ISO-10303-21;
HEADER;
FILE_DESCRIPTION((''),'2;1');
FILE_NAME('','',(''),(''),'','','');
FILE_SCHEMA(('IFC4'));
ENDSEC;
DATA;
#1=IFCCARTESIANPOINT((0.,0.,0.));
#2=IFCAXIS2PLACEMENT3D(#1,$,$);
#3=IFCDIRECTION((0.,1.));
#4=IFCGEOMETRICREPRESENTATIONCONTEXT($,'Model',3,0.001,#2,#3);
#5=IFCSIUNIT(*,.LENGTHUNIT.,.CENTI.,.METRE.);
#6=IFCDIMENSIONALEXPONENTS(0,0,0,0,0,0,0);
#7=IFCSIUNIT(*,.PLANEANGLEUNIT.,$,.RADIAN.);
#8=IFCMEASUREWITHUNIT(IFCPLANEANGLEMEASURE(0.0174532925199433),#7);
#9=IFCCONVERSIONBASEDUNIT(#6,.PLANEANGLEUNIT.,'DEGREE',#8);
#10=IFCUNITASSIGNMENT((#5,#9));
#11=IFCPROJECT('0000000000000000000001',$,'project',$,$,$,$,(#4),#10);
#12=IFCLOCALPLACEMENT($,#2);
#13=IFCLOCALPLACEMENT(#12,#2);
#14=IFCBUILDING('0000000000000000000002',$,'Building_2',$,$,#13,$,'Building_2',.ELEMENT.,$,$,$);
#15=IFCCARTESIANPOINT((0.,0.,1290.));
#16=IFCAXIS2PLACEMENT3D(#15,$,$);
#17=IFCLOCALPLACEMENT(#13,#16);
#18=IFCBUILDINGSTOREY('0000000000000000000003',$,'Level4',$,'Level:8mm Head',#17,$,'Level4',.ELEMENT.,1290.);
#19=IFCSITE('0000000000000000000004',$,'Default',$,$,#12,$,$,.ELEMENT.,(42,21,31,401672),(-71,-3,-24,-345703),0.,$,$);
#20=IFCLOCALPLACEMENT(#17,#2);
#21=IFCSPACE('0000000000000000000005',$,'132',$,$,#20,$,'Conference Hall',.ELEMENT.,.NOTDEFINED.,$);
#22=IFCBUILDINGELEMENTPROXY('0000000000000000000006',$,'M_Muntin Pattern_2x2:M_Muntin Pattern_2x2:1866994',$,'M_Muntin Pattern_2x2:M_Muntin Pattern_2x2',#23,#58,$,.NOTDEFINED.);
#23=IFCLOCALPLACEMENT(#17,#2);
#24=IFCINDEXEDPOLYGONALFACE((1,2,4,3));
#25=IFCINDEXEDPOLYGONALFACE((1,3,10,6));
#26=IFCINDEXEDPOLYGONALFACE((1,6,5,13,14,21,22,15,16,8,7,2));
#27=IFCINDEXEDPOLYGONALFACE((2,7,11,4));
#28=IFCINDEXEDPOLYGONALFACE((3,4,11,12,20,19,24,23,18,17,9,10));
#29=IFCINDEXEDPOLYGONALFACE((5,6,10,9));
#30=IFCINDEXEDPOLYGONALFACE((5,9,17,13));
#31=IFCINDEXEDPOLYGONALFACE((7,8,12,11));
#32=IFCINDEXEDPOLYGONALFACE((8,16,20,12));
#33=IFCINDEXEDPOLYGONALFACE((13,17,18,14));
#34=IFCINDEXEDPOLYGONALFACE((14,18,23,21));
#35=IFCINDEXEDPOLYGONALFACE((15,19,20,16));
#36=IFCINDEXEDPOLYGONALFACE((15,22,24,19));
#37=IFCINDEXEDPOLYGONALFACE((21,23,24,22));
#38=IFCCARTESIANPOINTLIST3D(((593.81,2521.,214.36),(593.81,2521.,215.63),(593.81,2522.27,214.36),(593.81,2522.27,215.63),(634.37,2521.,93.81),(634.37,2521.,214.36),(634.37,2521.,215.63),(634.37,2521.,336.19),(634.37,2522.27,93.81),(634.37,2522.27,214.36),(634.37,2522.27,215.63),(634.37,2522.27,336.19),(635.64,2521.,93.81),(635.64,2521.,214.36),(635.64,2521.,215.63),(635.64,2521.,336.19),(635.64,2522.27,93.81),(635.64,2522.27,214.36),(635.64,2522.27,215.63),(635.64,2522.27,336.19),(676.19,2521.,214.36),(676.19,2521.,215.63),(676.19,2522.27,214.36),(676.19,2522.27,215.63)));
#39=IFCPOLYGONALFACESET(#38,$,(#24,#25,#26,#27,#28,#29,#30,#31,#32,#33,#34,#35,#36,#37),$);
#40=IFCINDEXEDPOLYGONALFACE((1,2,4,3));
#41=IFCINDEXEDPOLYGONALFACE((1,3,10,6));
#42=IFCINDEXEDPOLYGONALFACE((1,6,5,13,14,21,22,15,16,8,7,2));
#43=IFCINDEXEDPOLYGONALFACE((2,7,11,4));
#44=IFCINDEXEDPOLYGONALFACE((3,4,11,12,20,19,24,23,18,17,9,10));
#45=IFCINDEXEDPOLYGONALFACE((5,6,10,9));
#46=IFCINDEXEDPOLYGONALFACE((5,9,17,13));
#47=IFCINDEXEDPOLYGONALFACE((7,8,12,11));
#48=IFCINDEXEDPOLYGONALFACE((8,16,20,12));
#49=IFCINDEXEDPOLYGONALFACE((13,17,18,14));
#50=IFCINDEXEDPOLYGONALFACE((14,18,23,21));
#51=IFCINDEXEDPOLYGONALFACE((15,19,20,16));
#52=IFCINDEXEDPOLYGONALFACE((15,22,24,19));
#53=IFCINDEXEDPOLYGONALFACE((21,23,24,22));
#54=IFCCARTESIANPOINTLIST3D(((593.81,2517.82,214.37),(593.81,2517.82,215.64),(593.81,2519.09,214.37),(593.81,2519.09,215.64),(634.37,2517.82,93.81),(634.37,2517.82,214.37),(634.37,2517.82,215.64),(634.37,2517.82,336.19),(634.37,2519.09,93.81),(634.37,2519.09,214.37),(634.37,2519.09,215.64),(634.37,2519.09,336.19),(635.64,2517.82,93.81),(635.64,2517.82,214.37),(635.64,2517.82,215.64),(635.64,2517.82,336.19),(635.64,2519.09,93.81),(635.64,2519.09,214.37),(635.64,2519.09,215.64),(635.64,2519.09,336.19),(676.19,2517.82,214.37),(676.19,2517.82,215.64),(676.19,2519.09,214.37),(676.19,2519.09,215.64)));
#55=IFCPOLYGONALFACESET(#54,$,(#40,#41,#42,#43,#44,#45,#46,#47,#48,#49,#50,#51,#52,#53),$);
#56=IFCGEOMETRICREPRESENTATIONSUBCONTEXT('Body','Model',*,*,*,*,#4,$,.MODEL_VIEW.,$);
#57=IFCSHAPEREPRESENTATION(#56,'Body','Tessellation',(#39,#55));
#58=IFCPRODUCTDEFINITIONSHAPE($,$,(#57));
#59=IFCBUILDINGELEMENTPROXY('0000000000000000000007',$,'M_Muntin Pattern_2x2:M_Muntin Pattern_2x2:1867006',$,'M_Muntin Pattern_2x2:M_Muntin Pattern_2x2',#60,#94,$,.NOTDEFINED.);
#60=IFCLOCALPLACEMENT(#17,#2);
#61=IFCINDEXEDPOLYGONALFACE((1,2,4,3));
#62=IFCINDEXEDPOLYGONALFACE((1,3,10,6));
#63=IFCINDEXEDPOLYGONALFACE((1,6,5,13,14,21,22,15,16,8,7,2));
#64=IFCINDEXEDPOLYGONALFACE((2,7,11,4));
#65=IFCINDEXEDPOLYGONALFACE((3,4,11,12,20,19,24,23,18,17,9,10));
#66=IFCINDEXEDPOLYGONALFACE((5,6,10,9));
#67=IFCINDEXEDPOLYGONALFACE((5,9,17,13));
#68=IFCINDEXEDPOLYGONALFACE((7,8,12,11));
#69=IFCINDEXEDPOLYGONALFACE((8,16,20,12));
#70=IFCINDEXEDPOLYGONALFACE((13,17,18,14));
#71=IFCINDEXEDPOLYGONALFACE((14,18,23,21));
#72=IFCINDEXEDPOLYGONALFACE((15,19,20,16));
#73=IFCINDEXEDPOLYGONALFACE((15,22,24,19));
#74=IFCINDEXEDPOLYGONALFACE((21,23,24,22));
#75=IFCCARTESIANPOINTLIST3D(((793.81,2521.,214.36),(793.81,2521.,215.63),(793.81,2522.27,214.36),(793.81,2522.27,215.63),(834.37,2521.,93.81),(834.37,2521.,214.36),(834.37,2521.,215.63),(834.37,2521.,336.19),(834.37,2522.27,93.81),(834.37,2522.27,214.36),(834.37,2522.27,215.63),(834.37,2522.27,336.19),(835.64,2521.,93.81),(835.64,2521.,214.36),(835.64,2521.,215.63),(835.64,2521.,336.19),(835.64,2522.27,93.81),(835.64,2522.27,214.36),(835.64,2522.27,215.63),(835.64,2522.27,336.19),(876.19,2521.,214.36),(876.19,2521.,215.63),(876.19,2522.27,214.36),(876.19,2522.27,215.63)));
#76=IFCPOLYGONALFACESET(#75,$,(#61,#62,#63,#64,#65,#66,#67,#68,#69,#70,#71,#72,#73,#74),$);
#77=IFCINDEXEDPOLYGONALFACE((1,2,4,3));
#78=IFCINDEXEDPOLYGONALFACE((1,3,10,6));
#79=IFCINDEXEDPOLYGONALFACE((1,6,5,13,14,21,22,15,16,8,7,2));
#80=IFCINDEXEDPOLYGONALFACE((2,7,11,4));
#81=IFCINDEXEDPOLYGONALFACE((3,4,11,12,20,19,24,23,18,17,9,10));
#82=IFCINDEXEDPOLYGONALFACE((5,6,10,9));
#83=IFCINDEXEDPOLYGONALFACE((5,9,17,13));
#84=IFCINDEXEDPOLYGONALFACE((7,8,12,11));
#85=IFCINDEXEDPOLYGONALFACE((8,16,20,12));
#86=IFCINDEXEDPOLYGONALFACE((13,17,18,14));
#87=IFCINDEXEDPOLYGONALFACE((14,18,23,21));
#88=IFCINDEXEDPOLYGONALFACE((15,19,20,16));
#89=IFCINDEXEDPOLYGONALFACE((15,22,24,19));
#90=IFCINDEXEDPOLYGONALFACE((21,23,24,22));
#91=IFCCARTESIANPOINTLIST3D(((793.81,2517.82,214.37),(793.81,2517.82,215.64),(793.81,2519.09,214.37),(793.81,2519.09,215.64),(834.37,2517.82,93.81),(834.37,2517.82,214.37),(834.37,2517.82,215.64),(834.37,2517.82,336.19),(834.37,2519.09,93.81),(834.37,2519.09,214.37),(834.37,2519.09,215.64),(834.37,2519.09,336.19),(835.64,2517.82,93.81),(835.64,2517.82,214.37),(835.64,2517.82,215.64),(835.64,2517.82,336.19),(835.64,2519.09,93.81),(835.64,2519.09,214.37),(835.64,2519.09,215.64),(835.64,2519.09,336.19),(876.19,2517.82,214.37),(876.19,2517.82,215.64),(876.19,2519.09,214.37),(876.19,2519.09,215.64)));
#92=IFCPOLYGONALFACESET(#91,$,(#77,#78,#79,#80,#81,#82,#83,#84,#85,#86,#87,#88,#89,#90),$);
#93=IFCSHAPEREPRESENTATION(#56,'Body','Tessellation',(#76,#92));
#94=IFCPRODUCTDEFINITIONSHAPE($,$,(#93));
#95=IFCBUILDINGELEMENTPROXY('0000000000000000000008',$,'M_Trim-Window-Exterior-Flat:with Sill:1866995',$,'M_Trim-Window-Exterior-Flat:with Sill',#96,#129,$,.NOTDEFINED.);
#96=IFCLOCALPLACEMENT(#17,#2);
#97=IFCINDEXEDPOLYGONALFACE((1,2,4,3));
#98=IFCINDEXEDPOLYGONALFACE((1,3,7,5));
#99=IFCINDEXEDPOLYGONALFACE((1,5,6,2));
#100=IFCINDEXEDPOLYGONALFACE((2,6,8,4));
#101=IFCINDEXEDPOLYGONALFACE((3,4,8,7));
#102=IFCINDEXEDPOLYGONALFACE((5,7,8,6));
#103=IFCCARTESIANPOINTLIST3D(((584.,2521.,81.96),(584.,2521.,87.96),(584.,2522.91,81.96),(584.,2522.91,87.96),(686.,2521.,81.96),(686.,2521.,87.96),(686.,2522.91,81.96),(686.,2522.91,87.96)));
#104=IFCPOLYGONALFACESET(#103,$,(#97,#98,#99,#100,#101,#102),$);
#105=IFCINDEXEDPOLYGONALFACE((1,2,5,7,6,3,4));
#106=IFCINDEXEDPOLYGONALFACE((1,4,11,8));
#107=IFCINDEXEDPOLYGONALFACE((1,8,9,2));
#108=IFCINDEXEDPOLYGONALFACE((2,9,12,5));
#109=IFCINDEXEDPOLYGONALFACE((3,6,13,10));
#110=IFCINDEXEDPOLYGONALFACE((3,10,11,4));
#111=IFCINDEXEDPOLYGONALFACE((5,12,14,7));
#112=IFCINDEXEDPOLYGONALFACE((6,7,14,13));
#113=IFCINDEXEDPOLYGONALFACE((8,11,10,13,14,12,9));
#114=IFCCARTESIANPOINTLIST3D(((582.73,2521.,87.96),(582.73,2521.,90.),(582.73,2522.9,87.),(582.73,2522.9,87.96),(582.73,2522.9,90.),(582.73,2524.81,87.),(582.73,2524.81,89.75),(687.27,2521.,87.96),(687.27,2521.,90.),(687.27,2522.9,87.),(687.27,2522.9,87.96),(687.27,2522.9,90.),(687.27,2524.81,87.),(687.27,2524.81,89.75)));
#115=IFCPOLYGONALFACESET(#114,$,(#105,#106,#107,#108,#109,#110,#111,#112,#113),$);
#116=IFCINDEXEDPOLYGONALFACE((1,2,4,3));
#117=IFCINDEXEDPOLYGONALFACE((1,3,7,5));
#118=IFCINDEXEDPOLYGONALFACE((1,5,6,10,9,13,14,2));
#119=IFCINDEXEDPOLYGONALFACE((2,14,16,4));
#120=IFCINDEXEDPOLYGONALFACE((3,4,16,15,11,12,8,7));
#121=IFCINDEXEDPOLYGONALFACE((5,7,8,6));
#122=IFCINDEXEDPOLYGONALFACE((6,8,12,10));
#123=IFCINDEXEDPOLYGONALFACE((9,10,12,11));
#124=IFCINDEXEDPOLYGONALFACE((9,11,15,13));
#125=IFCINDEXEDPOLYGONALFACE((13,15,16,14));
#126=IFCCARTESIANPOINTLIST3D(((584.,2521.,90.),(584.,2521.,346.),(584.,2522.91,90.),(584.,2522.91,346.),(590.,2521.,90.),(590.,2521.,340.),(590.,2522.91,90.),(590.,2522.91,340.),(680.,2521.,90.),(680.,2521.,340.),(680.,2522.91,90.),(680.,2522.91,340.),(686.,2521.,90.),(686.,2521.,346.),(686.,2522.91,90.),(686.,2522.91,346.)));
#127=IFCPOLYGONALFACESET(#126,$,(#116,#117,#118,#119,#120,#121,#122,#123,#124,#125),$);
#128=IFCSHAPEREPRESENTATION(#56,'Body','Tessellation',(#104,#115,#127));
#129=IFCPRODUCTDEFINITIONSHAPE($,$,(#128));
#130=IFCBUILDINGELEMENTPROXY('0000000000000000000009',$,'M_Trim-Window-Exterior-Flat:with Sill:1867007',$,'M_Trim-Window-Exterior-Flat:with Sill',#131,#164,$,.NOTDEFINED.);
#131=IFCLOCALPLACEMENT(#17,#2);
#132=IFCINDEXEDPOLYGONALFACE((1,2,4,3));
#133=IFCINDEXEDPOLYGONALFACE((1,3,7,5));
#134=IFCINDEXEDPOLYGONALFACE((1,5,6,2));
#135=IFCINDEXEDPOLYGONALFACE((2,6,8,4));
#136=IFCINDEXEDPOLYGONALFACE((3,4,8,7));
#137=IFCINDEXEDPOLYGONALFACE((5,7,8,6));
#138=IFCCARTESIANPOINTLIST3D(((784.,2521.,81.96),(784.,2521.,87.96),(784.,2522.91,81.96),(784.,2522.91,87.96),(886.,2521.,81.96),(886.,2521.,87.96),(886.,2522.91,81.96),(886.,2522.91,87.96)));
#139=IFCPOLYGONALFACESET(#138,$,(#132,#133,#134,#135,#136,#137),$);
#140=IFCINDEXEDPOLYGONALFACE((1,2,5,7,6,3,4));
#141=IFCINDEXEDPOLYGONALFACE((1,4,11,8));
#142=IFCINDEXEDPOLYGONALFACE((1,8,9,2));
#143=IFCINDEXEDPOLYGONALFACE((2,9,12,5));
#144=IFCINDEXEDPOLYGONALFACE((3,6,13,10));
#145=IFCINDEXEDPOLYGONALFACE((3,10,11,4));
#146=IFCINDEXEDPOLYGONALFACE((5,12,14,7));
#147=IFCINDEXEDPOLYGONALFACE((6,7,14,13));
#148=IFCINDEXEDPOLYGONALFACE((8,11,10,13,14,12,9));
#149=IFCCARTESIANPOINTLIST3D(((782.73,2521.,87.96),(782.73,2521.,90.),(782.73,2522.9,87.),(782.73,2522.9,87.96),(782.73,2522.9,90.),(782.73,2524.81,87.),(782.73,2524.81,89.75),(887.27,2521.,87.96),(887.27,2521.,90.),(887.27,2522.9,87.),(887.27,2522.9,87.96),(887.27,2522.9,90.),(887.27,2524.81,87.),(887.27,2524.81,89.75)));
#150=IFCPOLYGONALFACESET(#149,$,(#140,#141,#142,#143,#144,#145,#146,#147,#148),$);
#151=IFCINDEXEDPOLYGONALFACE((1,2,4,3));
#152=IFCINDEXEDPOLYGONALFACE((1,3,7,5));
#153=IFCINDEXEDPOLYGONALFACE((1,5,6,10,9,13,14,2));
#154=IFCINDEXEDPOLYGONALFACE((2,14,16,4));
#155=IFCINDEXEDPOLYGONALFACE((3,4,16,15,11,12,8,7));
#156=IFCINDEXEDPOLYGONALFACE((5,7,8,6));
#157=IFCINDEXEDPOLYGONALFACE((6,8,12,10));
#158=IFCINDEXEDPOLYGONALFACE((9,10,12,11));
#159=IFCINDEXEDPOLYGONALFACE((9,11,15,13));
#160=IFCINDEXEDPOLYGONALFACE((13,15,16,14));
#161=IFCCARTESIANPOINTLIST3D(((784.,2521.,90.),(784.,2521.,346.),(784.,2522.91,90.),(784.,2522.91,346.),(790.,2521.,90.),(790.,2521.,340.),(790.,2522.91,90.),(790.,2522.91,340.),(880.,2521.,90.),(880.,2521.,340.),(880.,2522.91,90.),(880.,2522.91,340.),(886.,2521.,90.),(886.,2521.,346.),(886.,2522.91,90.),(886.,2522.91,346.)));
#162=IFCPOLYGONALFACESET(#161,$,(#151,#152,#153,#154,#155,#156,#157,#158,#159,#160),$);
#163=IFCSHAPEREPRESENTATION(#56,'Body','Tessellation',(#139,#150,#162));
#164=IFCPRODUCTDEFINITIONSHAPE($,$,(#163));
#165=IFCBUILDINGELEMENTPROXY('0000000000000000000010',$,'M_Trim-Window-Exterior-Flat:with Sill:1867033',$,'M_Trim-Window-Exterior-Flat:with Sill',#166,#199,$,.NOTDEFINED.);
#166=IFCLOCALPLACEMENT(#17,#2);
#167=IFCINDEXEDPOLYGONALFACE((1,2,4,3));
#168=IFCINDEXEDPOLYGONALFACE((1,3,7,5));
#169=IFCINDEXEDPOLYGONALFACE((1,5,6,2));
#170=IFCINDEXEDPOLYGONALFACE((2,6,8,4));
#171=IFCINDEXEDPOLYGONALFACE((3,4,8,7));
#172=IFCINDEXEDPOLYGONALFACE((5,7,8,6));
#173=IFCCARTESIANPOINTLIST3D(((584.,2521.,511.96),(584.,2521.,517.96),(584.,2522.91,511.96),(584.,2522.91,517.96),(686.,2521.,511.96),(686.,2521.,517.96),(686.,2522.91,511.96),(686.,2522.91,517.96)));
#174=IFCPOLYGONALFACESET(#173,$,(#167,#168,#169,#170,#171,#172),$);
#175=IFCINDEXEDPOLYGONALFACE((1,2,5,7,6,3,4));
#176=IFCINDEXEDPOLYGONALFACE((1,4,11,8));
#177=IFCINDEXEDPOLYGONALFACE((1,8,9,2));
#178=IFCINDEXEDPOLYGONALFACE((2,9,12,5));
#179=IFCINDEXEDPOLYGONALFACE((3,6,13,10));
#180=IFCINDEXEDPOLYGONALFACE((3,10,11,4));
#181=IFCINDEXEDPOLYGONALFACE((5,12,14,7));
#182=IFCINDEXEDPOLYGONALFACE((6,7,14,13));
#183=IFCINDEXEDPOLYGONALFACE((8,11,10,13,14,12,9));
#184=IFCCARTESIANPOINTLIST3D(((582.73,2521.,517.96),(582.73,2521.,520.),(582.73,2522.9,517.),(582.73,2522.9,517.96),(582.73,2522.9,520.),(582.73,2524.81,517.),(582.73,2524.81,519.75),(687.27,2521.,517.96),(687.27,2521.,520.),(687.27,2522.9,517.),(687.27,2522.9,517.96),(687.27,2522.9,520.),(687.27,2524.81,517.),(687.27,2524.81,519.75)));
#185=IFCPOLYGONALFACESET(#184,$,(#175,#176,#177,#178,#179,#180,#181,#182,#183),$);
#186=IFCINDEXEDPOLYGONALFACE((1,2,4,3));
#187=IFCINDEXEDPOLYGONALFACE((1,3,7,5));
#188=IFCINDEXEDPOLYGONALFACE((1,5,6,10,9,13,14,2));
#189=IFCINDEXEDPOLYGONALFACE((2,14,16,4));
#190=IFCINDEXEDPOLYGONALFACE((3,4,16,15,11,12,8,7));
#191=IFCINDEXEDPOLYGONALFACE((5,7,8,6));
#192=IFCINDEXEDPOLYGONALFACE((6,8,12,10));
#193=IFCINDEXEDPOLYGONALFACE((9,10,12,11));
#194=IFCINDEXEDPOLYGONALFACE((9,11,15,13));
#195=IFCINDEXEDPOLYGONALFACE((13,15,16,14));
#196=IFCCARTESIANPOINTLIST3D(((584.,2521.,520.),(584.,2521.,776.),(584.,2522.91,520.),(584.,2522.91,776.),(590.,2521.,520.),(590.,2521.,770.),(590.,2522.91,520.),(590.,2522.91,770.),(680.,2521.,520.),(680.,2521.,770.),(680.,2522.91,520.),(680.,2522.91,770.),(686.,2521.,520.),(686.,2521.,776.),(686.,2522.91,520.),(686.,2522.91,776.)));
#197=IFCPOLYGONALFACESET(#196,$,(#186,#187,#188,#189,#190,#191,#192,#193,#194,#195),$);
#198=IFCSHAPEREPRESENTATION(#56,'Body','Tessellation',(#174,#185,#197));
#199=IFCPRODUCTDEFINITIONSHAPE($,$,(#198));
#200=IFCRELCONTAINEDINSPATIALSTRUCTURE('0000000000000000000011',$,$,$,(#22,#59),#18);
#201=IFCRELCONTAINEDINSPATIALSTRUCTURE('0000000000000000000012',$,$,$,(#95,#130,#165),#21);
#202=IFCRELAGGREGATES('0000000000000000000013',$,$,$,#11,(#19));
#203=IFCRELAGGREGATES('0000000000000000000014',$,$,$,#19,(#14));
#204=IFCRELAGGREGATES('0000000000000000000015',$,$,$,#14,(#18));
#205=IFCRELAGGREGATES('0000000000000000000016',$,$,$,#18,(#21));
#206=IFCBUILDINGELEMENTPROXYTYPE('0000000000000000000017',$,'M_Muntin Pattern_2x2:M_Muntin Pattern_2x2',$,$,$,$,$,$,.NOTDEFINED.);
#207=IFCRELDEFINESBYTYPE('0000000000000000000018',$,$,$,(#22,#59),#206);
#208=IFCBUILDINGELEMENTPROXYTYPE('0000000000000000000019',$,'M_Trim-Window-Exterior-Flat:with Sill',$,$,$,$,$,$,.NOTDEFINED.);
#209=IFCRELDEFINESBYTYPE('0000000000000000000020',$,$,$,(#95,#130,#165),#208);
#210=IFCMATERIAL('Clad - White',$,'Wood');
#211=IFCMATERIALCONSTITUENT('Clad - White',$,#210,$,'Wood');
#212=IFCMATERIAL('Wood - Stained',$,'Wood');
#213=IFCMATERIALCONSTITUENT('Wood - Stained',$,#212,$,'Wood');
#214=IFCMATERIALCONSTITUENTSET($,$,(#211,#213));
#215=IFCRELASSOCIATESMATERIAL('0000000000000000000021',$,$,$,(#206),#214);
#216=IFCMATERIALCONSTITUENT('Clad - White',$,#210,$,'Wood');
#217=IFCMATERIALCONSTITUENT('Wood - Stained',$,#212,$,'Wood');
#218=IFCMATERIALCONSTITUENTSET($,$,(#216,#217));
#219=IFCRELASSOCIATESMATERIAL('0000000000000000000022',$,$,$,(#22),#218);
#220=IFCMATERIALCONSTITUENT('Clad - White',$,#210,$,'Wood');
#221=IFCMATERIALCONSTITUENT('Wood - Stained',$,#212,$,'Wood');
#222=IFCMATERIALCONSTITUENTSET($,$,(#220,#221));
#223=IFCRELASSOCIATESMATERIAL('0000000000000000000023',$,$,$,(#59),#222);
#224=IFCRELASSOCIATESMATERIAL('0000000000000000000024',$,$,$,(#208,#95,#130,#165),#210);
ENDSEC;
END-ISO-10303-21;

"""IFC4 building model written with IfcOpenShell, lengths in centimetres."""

from ifc_helpers import new_model, entity, si_unit, converted_unit, direction, frame, origin, place, context, subcontext, project, spatial, indexed_curve, outline, extrude, source, transform, mapped, material, constituent, constituent_set, type_object, type_shapes, element, save


model = new_model("IFC4")

# Units and contexts
model_context = context("Model", 3, precision=0.001, world=origin(), true_north=direction((0.0, 1.0)))
body_context = subcontext(model_context, "Body", "Model", "MODEL_VIEW")
ifc_project = project(units=[si_unit("LENGTHUNIT", "METRE", prefix="CENTI"), converted_unit("PLANEANGLEUNIT", "DEGREE", entity("IfcPlaneAngleMeasure", 0.0174532925199433), si_unit("PLANEANGLEUNIT", "RADIAN"), dimensions=[0, 0, 0, 0, 0, 0, 0])], contexts=[model_context])

# Site, building, storey
site_placement = place(None, origin())
site = spatial("IfcSite", under=ifc_project, at=site_placement, Name="Default", CompositionType="ELEMENT", RefLatitude=(42, 21, 31, 401672), RefLongitude=(-71, -3, -24, -345703), RefElevation=0.0)
building_placement = place(site_placement, origin())
building = spatial("IfcBuilding", under=site, at=building_placement, Name="Building_2", LongName="Building_2", CompositionType="ELEMENT")
storey_placement = place(building_placement, frame((0.0, 0.0, 1290.0)))
storey = spatial("IfcBuildingStorey", under=building, at=storey_placement, Name="Level4", ObjectType="Level:8mm Head", LongName="Level4", CompositionType="ELEMENT", Elevation=1290.0)

# Shared definitions
ifc_material_1 = material(Name="Clad - White", Category="Wood")
ifc_material_2 = material(Name="Wood - Stained", Category="Wood")

# Building element proxies
ifc_constituent_1 = constituent(ifc_material_1, Name="Clad - White", Category="Wood")
ifc_constituent_2 = constituent(ifc_material_2, Name="Wood - Stained", Category="Wood")
ifc_constituent_set_1 = constituent_set(constituents=[ifc_constituent_1, ifc_constituent_2])
ifc_constituent_3 = constituent(ifc_material_1, Name="Clad - White", Category="Wood")
ifc_constituent_4 = constituent(ifc_material_2, Name="Wood - Stained", Category="Wood")
ifc_constituent_set_2 = constituent_set(constituents=[ifc_constituent_3, ifc_constituent_4])
building_element_proxy_type_1 = type_object("IfcBuildingElementProxyType", Name="M_Muntin Pattern_2x2:M_Muntin Pattern_2x2", PredefinedType="NOTDEFINED", material=ifc_constituent_set_2)
shared_shape_1 = source(origin(), body_context, "Body", "SweptSolid", [
    extrude(outline(indexed_curve([(0.64, -0.64), (121.19, -0.64), (121.19, 0.63), (0.64, 0.63), (0.64, 41.19), (-0.63, 41.19), (-0.63, 0.63), (-121.19, 0.63), (-121.19, -0.64), (-0.63, -0.64), (-0.63, -41.19), (0.64, -41.19), (0.64, -0.64)], self_intersect=False)), frame((0.0, -2.22, 121.19), z_axis=(0.0, 1.0, 0.0), x_axis=(0.0, 0.0, 1.0)), (0.0, 0.0, 1.0), 1.27),
    extrude(outline(indexed_curve([(0.64, -0.64), (121.19, -0.64), (121.19, 0.63), (0.64, 0.63), (0.64, 41.19), (-0.63, 41.19), (-0.63, 0.63), (-121.19, 0.63), (-121.19, -0.64), (-0.63, -0.64), (-0.63, -41.19), (0.64, -41.19), (0.64, -0.64)], self_intersect=False)), frame((0.0, 0.95, 121.19), z_axis=(0.0, 1.0, 0.0), x_axis=(0.0, 0.0, 1.0)), (0.0, 0.0, 1.0), 1.27),
])
type_shapes(building_element_proxy_type_1, [shared_shape_1])
proxy_1_placement = place(storey_placement, frame((635.0, 2520.05, 93.81), z_axis=(0.0, 0.0, 1.0), x_axis=(-1.0, 0.0, 0.0)))
element("IfcBuildingElementProxy", 1, at=proxy_1_placement, inside=storey, type_object=building_element_proxy_type_1, material=ifc_constituent_set_1, Name="M_Muntin Pattern_2x2:M_Muntin Pattern_2x2:1866994", ObjectType="M_Muntin Pattern_2x2:M_Muntin Pattern_2x2", PredefinedType="NOTDEFINED", context=body_context, shape_type="MappedRepresentation", body=[
    mapped(shared_shape_1, transform((0.0, 0.0, 0.0), scale=1.0)),
])
ifc_constituent_5 = constituent(ifc_material_1, Name="Clad - White", Category="Wood")
ifc_constituent_6 = constituent(ifc_material_2, Name="Wood - Stained", Category="Wood")
ifc_constituent_set_3 = constituent_set(constituents=[ifc_constituent_5, ifc_constituent_6])
proxy_2_placement = place(storey_placement, frame((835.0, 2520.05, 93.81), z_axis=(0.0, 0.0, 1.0), x_axis=(-1.0, 0.0, 0.0)))
element("IfcBuildingElementProxy", 2, at=proxy_2_placement, inside=storey, type_object=building_element_proxy_type_1, material=ifc_constituent_set_3, Name="M_Muntin Pattern_2x2:M_Muntin Pattern_2x2:1867006", ObjectType="M_Muntin Pattern_2x2:M_Muntin Pattern_2x2", PredefinedType="NOTDEFINED", context=body_context, shape_type="MappedRepresentation", body=[
    mapped(shared_shape_1, transform((0.0, 0.0, 0.0), scale=1.0)),
])

# Shared definitions
space_1_placement = place(storey_placement, origin())
space_1 = spatial("IfcSpace", under=storey, at=space_1_placement, Name="132", LongName="Conference Hall", CompositionType="ELEMENT", PredefinedType="NOTDEFINED")

# Building element proxies
building_element_proxy_type_2 = type_object("IfcBuildingElementProxyType", Name="M_Trim-Window-Exterior-Flat:with Sill", PredefinedType="NOTDEFINED", material=ifc_material_1)
shared_shape_2 = source(origin(), body_context, "Body", "SweptSolid", [
    extrude(outline(indexed_curve([(-51.0, -3.0), (51.0, -3.0), (51.0, 3.0), (-51.0, 3.0), (-51.0, -3.0)], self_intersect=False)), frame((0.0, -255.04, 0.0), z_axis=(0.0, 0.0, 1.0), x_axis=(-1.0, 0.0, 0.0)), (0.0, 0.0, 1.0), 1.91),
    extrude(outline(indexed_curve([(-1.9, -1.52), (0.0, -1.52), (0.0, -0.57), (1.9, -0.57), (1.9, 1.48), (0.0, 1.48), (-1.9, 1.23), (-1.9, -1.52)], self_intersect=False)), frame((-52.27, -251.48, 1.9), z_axis=(1.0, 0.0, 0.0), x_axis=(0.0, 0.0, -1.0)), (0.0, 0.0, 1.0), 104.54),
    extrude(outline(indexed_curve([(-129.5, -51.0), (126.5, -51.0), (126.5, -45.0), (-123.5, -45.0), (-123.5, 45.0), (126.5, 45.0), (126.5, 51.0), (-129.5, 51.0), (-129.5, -51.0)], self_intersect=False)), frame((0.0, -123.5, 0.0), z_axis=(0.0, 0.0, 1.0), x_axis=(0.0, -1.0, 0.0)), (0.0, 0.0, 1.0), 1.91),
])
type_shapes(building_element_proxy_type_2, [shared_shape_2])
for number, where, z_axis, x_axis, name in (
    (3, (635.0, 2521.0, 340.0), (0.0, 1.0, 0.0), (-1.0, 0.0, 0.0), "M_Trim-Window-Exterior-Flat:with Sill:1866995"),
    (4, (835.0, 2521.0, 340.0), (0.0, 1.0, 0.0), (-1.0, 0.0, 0.0), "M_Trim-Window-Exterior-Flat:with Sill:1867007"),
    (5, (635.0, 2521.0, 770.0), (0.0, 1.0, 0.0), (-1.0, 0.0, 0.0), "M_Trim-Window-Exterior-Flat:with Sill:1867033"),
):
    element("IfcBuildingElementProxy", number, at=place(space_1_placement, frame(where, z_axis=z_axis, x_axis=x_axis)), inside=space_1, type_object=building_element_proxy_type_2, material=ifc_material_1, Name=name, ObjectType="M_Trim-Window-Exterior-Flat:with Sill", PredefinedType="NOTDEFINED", context=body_context, shape_type="MappedRepresentation", body=[
        mapped(shared_shape_2, transform((0.0, 0.0, 0.0), scale=1.0)),
    ])

save(model, "model.ifc")
